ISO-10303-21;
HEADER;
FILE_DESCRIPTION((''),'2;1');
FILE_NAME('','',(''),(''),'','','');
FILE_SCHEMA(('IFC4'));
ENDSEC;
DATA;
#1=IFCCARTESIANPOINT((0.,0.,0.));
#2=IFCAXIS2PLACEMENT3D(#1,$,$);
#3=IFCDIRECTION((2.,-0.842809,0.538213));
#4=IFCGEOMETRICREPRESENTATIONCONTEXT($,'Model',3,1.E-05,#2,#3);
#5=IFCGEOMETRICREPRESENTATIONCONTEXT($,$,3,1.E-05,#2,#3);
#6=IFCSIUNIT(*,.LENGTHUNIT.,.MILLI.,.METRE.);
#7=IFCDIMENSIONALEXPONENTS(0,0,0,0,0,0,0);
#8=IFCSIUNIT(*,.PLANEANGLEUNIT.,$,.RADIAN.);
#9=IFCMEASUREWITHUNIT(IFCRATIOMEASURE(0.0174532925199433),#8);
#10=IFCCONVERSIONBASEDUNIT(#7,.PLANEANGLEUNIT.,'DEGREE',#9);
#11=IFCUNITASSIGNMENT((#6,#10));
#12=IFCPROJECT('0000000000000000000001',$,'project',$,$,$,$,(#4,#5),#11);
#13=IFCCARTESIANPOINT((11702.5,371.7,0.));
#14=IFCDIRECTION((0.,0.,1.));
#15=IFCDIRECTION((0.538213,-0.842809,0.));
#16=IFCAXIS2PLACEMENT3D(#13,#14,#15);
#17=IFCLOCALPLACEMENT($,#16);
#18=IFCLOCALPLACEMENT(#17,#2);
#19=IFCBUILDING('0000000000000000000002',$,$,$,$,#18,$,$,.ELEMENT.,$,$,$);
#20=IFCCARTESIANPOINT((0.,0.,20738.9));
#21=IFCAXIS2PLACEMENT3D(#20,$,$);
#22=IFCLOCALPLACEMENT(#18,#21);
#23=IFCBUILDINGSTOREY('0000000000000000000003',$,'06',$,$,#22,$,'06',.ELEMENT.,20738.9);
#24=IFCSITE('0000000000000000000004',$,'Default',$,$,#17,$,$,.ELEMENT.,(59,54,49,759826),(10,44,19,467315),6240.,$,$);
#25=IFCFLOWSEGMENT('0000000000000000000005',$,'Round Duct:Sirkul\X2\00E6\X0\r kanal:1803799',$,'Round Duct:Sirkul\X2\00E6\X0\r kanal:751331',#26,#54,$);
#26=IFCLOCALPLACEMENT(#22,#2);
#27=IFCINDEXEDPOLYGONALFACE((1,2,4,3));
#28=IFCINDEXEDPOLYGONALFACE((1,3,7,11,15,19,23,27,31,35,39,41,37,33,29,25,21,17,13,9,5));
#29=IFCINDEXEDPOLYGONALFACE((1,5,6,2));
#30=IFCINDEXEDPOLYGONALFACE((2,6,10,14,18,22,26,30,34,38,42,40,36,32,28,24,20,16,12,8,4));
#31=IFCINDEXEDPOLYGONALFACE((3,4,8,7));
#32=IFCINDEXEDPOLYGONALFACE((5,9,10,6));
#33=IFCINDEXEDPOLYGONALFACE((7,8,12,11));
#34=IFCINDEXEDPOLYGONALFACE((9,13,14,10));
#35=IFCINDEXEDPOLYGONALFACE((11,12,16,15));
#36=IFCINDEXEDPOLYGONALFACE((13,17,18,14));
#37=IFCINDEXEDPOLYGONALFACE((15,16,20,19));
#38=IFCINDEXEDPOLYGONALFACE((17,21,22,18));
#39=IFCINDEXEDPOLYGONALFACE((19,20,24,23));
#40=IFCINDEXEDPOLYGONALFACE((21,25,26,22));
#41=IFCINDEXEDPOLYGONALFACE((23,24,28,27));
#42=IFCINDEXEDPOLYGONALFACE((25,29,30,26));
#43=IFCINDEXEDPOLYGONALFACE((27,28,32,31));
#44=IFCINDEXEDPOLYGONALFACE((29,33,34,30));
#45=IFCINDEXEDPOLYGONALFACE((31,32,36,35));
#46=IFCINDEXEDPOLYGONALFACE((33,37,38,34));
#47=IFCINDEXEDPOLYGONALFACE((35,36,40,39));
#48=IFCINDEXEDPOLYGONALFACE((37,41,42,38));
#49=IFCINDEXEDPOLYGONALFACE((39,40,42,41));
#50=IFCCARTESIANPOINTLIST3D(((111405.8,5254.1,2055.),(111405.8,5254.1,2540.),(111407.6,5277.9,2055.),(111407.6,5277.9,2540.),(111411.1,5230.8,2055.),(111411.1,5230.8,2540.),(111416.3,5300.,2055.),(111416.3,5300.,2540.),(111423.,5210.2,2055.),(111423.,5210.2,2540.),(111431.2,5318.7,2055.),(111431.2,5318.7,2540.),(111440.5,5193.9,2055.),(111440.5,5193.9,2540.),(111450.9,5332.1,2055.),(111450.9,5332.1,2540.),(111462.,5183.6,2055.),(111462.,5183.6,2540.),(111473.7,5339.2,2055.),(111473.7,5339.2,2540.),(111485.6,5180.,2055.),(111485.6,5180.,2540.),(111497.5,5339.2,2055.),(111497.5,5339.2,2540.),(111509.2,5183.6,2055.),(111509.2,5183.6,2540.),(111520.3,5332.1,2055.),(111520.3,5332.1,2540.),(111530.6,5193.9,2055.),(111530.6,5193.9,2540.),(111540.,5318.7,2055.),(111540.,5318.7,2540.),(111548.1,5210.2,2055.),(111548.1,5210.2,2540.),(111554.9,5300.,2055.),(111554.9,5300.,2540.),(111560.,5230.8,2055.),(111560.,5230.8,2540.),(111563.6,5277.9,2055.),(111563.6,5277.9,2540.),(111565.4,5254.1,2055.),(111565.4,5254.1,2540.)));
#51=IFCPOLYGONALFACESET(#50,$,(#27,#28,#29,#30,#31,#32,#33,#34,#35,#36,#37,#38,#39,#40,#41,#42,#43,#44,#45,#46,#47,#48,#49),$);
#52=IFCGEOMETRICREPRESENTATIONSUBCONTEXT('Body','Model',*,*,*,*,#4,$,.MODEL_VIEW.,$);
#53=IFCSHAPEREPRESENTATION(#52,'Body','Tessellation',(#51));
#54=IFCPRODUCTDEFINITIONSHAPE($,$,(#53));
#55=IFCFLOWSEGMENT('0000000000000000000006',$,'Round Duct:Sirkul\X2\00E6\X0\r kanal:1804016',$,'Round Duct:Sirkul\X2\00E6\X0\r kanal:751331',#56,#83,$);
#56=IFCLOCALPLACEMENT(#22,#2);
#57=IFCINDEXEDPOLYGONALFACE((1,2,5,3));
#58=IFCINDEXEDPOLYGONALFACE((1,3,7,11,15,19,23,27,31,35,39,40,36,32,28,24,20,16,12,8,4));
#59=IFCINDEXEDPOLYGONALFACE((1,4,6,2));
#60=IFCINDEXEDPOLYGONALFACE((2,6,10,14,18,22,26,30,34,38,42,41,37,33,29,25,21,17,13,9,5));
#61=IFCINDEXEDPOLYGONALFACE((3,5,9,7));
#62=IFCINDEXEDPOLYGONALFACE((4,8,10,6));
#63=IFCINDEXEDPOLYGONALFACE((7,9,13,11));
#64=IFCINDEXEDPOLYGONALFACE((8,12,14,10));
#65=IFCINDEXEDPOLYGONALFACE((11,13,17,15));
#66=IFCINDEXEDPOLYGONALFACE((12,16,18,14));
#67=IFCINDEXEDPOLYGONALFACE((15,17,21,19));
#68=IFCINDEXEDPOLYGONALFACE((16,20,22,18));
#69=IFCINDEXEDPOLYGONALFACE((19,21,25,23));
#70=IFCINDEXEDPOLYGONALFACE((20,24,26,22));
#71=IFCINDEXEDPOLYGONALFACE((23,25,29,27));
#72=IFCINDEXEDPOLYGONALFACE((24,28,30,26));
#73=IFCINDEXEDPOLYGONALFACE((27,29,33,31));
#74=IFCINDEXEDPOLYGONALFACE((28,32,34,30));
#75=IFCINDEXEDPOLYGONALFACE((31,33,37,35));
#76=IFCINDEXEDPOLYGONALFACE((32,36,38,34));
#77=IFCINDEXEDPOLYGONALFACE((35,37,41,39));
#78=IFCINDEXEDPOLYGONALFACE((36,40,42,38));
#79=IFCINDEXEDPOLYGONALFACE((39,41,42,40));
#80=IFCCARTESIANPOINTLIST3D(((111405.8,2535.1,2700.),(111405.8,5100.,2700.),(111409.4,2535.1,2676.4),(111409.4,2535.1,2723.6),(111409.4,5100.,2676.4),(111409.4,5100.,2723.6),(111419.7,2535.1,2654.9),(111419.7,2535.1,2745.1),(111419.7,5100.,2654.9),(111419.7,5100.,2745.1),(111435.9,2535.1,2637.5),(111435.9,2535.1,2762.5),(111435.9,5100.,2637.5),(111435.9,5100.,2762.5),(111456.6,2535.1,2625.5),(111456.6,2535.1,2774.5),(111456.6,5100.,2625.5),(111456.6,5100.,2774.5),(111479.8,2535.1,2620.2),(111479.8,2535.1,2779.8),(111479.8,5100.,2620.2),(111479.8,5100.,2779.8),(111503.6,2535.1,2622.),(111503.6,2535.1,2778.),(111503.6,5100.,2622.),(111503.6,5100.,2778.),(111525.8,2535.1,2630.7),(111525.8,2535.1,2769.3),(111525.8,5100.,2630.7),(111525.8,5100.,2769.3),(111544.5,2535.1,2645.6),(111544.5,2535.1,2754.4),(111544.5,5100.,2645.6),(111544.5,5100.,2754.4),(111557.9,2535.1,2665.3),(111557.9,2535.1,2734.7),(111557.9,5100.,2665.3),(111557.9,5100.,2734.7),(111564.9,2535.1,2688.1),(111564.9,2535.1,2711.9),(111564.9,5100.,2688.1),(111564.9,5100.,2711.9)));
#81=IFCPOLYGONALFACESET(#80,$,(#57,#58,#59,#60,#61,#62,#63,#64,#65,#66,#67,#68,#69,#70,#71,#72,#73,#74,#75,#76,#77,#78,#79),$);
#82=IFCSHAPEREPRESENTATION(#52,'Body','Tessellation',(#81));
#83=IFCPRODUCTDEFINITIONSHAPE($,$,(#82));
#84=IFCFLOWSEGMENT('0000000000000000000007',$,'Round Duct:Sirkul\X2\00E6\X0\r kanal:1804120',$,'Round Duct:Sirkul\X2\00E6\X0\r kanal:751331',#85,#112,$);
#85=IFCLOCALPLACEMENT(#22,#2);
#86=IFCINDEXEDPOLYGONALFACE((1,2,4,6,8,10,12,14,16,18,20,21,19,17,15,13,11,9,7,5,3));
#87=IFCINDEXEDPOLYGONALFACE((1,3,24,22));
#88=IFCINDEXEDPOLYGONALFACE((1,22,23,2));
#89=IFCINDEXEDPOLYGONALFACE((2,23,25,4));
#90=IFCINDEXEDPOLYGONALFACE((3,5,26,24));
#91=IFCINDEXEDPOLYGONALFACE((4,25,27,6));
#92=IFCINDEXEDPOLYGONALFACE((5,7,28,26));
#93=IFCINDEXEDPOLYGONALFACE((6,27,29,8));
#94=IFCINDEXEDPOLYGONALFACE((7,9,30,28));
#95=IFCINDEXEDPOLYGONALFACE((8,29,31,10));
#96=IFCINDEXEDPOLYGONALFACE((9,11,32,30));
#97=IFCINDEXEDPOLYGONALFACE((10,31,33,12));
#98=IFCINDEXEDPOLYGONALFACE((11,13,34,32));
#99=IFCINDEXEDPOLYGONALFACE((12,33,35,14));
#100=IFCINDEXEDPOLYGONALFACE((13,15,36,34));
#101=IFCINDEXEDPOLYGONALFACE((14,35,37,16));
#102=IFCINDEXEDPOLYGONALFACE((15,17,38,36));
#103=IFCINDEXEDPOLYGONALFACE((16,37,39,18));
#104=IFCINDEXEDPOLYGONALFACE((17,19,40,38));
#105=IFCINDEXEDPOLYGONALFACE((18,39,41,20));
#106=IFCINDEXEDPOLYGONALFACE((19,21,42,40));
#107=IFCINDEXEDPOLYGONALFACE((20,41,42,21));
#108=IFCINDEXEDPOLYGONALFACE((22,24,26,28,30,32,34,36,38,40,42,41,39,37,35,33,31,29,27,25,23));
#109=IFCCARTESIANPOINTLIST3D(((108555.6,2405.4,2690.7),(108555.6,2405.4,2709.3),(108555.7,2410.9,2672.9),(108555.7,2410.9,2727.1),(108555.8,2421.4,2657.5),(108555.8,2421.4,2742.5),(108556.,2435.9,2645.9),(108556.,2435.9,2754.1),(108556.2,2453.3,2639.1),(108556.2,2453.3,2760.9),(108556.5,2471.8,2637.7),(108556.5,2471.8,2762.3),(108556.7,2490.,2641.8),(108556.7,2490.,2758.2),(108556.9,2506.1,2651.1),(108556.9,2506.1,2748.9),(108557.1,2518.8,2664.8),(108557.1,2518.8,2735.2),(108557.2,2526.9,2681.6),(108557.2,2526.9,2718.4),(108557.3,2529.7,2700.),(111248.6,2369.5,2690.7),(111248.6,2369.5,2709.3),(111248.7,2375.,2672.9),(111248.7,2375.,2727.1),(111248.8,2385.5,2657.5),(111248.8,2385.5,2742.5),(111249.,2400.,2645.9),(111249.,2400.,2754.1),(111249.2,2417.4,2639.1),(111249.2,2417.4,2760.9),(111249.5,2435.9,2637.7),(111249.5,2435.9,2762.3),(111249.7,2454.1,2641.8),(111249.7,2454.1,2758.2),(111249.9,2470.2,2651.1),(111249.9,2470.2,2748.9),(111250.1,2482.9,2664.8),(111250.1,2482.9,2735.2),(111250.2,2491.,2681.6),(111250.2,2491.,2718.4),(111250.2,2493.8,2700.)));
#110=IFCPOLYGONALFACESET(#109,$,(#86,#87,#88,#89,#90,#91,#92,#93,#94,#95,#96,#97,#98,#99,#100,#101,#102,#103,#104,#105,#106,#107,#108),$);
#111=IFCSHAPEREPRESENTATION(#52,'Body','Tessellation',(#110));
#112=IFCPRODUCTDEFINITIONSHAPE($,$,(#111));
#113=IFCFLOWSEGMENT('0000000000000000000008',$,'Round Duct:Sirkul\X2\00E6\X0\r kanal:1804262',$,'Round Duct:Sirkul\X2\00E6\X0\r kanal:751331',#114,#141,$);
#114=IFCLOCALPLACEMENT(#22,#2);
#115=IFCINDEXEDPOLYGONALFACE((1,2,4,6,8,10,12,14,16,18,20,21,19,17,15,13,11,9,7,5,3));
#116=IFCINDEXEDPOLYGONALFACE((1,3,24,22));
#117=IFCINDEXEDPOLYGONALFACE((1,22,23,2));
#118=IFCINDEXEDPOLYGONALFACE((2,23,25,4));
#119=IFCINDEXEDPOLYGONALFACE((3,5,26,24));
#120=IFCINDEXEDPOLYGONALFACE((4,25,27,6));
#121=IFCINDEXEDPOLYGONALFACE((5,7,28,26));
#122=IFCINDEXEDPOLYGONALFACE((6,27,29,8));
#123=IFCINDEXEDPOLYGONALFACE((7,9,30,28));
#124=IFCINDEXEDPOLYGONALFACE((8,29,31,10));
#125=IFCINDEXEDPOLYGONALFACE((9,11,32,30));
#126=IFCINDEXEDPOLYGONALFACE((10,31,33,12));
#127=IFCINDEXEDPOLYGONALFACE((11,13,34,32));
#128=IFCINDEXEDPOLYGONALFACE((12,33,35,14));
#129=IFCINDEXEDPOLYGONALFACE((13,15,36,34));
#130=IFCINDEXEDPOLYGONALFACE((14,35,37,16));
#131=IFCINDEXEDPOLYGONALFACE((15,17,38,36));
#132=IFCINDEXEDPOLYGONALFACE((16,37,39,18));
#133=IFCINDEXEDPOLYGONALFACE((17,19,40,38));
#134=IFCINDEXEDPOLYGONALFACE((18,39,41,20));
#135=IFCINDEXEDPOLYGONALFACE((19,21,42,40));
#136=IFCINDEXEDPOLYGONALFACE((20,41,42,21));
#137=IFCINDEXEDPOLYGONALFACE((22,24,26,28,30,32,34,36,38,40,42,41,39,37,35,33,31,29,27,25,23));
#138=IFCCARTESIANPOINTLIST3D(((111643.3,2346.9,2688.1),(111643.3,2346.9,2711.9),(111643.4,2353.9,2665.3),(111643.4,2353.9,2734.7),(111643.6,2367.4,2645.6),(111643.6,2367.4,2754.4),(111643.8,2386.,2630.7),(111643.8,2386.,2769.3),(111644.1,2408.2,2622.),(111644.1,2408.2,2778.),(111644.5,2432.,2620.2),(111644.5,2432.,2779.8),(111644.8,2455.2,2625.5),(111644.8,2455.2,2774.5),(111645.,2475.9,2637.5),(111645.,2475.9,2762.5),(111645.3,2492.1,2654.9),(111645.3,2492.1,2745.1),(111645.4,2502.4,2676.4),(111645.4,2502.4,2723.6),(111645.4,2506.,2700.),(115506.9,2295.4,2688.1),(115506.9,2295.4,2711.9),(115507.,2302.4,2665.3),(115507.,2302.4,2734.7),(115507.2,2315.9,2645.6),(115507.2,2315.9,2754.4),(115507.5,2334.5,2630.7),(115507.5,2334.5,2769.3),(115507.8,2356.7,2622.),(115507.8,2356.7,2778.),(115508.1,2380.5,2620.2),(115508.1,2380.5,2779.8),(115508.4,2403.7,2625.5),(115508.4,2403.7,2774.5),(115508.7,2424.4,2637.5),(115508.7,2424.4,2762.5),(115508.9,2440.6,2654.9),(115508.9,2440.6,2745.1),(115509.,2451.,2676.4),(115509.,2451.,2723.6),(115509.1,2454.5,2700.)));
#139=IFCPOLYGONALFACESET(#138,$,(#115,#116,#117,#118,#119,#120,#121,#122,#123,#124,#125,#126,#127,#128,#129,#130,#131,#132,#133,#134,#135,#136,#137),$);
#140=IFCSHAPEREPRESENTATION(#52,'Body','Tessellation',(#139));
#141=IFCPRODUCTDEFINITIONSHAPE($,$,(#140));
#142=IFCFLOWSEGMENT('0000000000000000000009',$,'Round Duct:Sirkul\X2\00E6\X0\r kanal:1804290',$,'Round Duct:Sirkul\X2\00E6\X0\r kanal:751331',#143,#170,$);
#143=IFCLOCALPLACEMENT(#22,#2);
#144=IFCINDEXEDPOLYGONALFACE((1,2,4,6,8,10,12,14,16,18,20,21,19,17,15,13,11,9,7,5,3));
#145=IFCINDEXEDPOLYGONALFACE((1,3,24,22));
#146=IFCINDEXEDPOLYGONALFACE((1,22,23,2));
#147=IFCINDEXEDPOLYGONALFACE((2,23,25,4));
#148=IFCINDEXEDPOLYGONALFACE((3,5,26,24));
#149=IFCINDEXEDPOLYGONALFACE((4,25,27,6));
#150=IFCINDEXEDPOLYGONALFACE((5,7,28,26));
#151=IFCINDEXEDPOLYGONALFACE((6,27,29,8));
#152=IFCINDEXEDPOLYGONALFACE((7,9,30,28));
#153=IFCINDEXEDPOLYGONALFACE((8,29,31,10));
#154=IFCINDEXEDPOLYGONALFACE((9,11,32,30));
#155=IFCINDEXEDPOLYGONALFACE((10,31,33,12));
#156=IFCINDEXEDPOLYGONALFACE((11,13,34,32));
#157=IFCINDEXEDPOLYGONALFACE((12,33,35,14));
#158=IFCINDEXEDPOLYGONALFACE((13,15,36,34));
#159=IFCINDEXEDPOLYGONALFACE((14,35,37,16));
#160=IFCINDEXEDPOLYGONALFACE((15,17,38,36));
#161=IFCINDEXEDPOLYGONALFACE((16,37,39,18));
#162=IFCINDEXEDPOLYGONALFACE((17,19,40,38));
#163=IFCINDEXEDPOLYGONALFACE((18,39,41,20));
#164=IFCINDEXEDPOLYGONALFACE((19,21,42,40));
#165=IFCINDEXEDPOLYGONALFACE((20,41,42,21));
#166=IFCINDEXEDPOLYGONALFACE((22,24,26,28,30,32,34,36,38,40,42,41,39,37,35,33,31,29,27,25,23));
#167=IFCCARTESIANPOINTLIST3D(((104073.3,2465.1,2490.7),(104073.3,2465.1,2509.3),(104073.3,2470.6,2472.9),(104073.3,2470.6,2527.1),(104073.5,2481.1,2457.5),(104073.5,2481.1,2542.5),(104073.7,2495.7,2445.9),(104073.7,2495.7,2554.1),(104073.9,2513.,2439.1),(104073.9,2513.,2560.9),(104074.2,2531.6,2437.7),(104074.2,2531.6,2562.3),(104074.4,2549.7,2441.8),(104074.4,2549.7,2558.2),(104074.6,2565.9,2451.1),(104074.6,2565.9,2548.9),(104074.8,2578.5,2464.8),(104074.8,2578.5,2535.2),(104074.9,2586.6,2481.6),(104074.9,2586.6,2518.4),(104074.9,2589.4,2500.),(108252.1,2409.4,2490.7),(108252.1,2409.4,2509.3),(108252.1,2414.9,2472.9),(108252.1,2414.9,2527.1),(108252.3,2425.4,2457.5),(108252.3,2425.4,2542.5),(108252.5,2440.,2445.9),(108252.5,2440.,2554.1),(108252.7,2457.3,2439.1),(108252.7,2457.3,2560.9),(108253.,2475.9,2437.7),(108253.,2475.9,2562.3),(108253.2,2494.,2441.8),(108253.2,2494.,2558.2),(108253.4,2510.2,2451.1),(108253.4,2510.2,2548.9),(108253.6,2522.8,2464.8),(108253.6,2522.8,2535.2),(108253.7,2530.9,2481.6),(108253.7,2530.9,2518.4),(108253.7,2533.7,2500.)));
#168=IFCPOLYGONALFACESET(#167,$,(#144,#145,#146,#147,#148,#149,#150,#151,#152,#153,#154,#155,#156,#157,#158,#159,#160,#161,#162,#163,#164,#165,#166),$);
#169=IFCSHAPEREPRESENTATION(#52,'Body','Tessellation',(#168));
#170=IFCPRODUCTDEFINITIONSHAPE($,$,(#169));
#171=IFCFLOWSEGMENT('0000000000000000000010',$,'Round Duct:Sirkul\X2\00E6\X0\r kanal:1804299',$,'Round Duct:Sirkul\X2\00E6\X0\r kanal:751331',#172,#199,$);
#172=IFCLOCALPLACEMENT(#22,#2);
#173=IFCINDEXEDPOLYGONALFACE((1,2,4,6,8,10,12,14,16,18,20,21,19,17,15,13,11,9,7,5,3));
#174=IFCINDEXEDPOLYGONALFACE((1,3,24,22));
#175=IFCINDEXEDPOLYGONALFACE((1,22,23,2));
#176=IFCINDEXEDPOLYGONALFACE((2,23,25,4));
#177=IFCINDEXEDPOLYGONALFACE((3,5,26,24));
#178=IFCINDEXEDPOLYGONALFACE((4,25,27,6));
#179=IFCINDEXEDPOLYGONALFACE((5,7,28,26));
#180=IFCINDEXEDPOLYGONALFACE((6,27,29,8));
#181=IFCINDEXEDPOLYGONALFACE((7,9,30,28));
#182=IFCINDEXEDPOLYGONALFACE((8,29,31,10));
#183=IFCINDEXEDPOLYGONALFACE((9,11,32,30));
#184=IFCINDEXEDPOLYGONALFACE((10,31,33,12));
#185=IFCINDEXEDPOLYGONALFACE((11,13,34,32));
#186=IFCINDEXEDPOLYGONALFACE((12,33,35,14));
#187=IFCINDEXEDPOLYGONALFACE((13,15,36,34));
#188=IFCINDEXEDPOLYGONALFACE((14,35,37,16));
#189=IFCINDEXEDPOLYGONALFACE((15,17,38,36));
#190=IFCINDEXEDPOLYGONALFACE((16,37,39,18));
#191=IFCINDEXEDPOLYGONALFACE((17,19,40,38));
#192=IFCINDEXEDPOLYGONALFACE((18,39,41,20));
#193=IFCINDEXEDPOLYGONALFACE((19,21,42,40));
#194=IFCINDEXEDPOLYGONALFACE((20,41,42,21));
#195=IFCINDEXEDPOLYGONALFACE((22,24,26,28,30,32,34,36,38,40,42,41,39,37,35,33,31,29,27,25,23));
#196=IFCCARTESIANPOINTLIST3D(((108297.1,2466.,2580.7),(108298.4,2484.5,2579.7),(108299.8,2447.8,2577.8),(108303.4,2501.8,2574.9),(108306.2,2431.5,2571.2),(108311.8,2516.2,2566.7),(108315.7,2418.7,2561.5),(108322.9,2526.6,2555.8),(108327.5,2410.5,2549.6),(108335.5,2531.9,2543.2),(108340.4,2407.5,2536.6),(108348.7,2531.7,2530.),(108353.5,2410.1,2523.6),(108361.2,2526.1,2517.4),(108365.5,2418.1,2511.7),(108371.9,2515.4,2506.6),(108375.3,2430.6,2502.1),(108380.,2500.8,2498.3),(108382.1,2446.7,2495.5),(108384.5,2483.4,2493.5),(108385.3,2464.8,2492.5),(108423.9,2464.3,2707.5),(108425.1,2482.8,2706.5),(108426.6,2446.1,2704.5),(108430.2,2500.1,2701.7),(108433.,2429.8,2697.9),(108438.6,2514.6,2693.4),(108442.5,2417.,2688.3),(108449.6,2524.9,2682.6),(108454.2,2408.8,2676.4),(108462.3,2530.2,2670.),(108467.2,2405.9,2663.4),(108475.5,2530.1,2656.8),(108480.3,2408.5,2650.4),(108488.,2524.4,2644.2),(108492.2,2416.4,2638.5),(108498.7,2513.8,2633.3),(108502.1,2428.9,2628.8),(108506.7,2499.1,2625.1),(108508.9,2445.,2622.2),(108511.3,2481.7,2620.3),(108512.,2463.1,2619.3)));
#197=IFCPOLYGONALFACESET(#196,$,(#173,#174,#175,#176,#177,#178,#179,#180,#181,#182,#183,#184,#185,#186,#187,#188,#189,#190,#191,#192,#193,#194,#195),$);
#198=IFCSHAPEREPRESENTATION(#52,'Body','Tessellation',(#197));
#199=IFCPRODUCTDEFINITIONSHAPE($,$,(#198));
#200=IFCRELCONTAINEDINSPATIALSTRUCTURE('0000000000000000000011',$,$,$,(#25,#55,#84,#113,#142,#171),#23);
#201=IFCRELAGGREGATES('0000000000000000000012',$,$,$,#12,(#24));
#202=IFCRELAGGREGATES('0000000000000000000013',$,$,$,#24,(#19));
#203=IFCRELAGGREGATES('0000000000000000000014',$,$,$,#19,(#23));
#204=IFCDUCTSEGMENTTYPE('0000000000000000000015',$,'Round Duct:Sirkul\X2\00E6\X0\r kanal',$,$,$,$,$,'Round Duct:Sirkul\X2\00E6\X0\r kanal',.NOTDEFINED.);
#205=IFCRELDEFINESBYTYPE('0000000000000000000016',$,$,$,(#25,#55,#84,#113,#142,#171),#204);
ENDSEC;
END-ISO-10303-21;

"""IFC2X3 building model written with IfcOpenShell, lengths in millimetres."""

from ifc_helpers import new_model, entity, si_unit, converted_unit, direction, frame, frame_2d, origin, origin_2d_with_axis, place, context, subcontext, project, spatial, circle, extrude, type_object, element, save


model = new_model("IFC2X3")

# Units and contexts
model_context = context("Model", 3, precision=1e-05, world=origin(), true_north=direction((2.0, -0.842809, 0.538213)))
context_of_model = context(None, 3, precision=1e-05, world=origin(), true_north=direction((2.0, -0.842809, 0.538213)))
body_context = subcontext(model_context, "Body", "Model", "MODEL_VIEW")
ifc_project = project(units=[si_unit("LENGTHUNIT", "METRE", prefix="MILLI"), converted_unit("PLANEANGLEUNIT", "DEGREE", entity("IfcRatioMeasure", 0.0174532925199433), si_unit("PLANEANGLEUNIT", "RADIAN"), dimensions=[0, 0, 0, 0, 0, 0, 0])], contexts=[model_context, context_of_model])

# Site, building, storey
site_placement = place(None, frame((11702.5, 371.7, 0.0), z_axis=(0.0, 0.0, 1.0), x_axis=(0.538213, -0.842809, 0.0)))
site = spatial("IfcSite", under=ifc_project, at=site_placement, Name="Default", CompositionType="ELEMENT", RefLatitude=(59, 54, 49, 759826), RefLongitude=(10, 44, 19, 467315), RefElevation=6240.0)
building_placement = place(site_placement, origin())
building = spatial("IfcBuilding", under=site, at=building_placement, CompositionType="ELEMENT")
storey_placement = place(building_placement, frame((0.0, 0.0, 20738.9)))
storey = spatial("IfcBuildingStorey", under=building, at=storey_placement, Name="06", LongName="06", CompositionType="ELEMENT", Elevation=20738.9)

# Flow segments
duct_segment_type = type_object("IfcDuctSegmentType", Name="Round Duct:Sirkulær kanal", ElementType="Round Duct:Sirkulær kanal", PredefinedType="NOTDEFINED")
flow_segment_1_placement = place(storey_placement, origin())
element("IfcFlowSegment", 1, at=flow_segment_1_placement, inside=storey, type_object=duct_segment_type, Name="Round Duct:Sirkulær kanal:1803799", ObjectType="Round Duct:Sirkulær kanal:751331", context=body_context, shape_type="SweptSolid", body=[
    extrude(circle(Radius=80.0, at=origin_2d_with_axis()), frame((111485.6, 5260.0, 2055.0), z_axis=(0.0, 0.0, 1.0), x_axis=(0.0, -1.0, 0.0)), (0.0, 0.0, 1.0), 485.0),
])
flow_segment_2_placement = place(storey_placement, origin())
element("IfcFlowSegment", 2, at=flow_segment_2_placement, inside=storey, type_object=duct_segment_type, Name="Round Duct:Sirkulær kanal:1804016", ObjectType="Round Duct:Sirkulær kanal:751331", context=body_context, shape_type="SweptSolid", body=[
    extrude(circle(Radius=80.0, at=frame_2d((0.0, 0.0), x_axis=(1.0, 0.0))), frame((111485.8, 2535.1, 2700.0), z_axis=(0.0, 1.0, 0.0), x_axis=(-1.0, 0.0, 0.0)), (0.0, 0.0, 1.0), 2564.9),
])
flow_segment_3_placement = place(storey_placement, origin())
element("IfcFlowSegment", 3, at=flow_segment_3_placement, inside=storey, type_object=duct_segment_type, Name="Round Duct:Sirkulær kanal:1804120", ObjectType="Round Duct:Sirkulær kanal:751331", context=body_context, shape_type="SweptSolid", body=[
    extrude(circle(Radius=62.5, at=frame_2d((0.0, 0.0), x_axis=(1.0, 0.0))), frame((108556.4, 2467.2, 2700.0), z_axis=(0.999911, -0.013327, 0.0), x_axis=(0.013327, 0.999911, 0.0)), (0.0, 0.0, 1.0), 2693.2),
])
flow_segment_4_placement = place(storey_placement, origin())
element("IfcFlowSegment", 4, at=flow_segment_4_placement, inside=storey, type_object=duct_segment_type, Name="Round Duct:Sirkulær kanal:1804262", ObjectType="Round Duct:Sirkulær kanal:751331", context=body_context, shape_type="SweptSolid", body=[
    extrude(circle(Radius=80.0, at=frame_2d((0.0, 0.0), x_axis=(1.0, 0.0))), frame((111644.4, 2426.0, 2700.0), z_axis=(0.999911, -0.013327, 0.0), x_axis=(0.013327, 0.999911, 0.0)), (0.0, 0.0, 1.0), 3864.0),
])
flow_segment_5_placement = place(storey_placement, origin())
element("IfcFlowSegment", 5, at=flow_segment_5_placement, inside=storey, type_object=duct_segment_type, Name="Round Duct:Sirkulær kanal:1804290", ObjectType="Round Duct:Sirkulær kanal:751331", context=body_context, shape_type="SweptSolid", body=[
    extrude(circle(Radius=62.5, at=frame_2d((0.0, 0.0), x_axis=(1.0, 0.0))), frame((104074.1, 2526.9, 2500.0), z_axis=(0.999911, -0.013327, 0.0), x_axis=(0.013327, 0.999911, 0.0)), (0.0, 0.0, 1.0), 4179.2),
])
flow_segment_6_placement = place(storey_placement, origin())
element("IfcFlowSegment", 6, at=flow_segment_6_placement, inside=storey, type_object=duct_segment_type, Name="Round Duct:Sirkulær kanal:1804299", ObjectType="Round Duct:Sirkulær kanal:751331", context=body_context, shape_type="SweptSolid", body=[
    extrude(circle(Radius=62.5, at=frame_2d((0.0, 0.0), x_axis=(1.0, 0.0))), frame((108468.0, 2468.3, 2663.4), z_axis=(-0.707044, 0.009424, -0.707107), x_axis=(-0.013327, -0.999911, 0.0)), (0.0, 0.0, 1.0), 179.3),
])

save(model, "model.ifc")
